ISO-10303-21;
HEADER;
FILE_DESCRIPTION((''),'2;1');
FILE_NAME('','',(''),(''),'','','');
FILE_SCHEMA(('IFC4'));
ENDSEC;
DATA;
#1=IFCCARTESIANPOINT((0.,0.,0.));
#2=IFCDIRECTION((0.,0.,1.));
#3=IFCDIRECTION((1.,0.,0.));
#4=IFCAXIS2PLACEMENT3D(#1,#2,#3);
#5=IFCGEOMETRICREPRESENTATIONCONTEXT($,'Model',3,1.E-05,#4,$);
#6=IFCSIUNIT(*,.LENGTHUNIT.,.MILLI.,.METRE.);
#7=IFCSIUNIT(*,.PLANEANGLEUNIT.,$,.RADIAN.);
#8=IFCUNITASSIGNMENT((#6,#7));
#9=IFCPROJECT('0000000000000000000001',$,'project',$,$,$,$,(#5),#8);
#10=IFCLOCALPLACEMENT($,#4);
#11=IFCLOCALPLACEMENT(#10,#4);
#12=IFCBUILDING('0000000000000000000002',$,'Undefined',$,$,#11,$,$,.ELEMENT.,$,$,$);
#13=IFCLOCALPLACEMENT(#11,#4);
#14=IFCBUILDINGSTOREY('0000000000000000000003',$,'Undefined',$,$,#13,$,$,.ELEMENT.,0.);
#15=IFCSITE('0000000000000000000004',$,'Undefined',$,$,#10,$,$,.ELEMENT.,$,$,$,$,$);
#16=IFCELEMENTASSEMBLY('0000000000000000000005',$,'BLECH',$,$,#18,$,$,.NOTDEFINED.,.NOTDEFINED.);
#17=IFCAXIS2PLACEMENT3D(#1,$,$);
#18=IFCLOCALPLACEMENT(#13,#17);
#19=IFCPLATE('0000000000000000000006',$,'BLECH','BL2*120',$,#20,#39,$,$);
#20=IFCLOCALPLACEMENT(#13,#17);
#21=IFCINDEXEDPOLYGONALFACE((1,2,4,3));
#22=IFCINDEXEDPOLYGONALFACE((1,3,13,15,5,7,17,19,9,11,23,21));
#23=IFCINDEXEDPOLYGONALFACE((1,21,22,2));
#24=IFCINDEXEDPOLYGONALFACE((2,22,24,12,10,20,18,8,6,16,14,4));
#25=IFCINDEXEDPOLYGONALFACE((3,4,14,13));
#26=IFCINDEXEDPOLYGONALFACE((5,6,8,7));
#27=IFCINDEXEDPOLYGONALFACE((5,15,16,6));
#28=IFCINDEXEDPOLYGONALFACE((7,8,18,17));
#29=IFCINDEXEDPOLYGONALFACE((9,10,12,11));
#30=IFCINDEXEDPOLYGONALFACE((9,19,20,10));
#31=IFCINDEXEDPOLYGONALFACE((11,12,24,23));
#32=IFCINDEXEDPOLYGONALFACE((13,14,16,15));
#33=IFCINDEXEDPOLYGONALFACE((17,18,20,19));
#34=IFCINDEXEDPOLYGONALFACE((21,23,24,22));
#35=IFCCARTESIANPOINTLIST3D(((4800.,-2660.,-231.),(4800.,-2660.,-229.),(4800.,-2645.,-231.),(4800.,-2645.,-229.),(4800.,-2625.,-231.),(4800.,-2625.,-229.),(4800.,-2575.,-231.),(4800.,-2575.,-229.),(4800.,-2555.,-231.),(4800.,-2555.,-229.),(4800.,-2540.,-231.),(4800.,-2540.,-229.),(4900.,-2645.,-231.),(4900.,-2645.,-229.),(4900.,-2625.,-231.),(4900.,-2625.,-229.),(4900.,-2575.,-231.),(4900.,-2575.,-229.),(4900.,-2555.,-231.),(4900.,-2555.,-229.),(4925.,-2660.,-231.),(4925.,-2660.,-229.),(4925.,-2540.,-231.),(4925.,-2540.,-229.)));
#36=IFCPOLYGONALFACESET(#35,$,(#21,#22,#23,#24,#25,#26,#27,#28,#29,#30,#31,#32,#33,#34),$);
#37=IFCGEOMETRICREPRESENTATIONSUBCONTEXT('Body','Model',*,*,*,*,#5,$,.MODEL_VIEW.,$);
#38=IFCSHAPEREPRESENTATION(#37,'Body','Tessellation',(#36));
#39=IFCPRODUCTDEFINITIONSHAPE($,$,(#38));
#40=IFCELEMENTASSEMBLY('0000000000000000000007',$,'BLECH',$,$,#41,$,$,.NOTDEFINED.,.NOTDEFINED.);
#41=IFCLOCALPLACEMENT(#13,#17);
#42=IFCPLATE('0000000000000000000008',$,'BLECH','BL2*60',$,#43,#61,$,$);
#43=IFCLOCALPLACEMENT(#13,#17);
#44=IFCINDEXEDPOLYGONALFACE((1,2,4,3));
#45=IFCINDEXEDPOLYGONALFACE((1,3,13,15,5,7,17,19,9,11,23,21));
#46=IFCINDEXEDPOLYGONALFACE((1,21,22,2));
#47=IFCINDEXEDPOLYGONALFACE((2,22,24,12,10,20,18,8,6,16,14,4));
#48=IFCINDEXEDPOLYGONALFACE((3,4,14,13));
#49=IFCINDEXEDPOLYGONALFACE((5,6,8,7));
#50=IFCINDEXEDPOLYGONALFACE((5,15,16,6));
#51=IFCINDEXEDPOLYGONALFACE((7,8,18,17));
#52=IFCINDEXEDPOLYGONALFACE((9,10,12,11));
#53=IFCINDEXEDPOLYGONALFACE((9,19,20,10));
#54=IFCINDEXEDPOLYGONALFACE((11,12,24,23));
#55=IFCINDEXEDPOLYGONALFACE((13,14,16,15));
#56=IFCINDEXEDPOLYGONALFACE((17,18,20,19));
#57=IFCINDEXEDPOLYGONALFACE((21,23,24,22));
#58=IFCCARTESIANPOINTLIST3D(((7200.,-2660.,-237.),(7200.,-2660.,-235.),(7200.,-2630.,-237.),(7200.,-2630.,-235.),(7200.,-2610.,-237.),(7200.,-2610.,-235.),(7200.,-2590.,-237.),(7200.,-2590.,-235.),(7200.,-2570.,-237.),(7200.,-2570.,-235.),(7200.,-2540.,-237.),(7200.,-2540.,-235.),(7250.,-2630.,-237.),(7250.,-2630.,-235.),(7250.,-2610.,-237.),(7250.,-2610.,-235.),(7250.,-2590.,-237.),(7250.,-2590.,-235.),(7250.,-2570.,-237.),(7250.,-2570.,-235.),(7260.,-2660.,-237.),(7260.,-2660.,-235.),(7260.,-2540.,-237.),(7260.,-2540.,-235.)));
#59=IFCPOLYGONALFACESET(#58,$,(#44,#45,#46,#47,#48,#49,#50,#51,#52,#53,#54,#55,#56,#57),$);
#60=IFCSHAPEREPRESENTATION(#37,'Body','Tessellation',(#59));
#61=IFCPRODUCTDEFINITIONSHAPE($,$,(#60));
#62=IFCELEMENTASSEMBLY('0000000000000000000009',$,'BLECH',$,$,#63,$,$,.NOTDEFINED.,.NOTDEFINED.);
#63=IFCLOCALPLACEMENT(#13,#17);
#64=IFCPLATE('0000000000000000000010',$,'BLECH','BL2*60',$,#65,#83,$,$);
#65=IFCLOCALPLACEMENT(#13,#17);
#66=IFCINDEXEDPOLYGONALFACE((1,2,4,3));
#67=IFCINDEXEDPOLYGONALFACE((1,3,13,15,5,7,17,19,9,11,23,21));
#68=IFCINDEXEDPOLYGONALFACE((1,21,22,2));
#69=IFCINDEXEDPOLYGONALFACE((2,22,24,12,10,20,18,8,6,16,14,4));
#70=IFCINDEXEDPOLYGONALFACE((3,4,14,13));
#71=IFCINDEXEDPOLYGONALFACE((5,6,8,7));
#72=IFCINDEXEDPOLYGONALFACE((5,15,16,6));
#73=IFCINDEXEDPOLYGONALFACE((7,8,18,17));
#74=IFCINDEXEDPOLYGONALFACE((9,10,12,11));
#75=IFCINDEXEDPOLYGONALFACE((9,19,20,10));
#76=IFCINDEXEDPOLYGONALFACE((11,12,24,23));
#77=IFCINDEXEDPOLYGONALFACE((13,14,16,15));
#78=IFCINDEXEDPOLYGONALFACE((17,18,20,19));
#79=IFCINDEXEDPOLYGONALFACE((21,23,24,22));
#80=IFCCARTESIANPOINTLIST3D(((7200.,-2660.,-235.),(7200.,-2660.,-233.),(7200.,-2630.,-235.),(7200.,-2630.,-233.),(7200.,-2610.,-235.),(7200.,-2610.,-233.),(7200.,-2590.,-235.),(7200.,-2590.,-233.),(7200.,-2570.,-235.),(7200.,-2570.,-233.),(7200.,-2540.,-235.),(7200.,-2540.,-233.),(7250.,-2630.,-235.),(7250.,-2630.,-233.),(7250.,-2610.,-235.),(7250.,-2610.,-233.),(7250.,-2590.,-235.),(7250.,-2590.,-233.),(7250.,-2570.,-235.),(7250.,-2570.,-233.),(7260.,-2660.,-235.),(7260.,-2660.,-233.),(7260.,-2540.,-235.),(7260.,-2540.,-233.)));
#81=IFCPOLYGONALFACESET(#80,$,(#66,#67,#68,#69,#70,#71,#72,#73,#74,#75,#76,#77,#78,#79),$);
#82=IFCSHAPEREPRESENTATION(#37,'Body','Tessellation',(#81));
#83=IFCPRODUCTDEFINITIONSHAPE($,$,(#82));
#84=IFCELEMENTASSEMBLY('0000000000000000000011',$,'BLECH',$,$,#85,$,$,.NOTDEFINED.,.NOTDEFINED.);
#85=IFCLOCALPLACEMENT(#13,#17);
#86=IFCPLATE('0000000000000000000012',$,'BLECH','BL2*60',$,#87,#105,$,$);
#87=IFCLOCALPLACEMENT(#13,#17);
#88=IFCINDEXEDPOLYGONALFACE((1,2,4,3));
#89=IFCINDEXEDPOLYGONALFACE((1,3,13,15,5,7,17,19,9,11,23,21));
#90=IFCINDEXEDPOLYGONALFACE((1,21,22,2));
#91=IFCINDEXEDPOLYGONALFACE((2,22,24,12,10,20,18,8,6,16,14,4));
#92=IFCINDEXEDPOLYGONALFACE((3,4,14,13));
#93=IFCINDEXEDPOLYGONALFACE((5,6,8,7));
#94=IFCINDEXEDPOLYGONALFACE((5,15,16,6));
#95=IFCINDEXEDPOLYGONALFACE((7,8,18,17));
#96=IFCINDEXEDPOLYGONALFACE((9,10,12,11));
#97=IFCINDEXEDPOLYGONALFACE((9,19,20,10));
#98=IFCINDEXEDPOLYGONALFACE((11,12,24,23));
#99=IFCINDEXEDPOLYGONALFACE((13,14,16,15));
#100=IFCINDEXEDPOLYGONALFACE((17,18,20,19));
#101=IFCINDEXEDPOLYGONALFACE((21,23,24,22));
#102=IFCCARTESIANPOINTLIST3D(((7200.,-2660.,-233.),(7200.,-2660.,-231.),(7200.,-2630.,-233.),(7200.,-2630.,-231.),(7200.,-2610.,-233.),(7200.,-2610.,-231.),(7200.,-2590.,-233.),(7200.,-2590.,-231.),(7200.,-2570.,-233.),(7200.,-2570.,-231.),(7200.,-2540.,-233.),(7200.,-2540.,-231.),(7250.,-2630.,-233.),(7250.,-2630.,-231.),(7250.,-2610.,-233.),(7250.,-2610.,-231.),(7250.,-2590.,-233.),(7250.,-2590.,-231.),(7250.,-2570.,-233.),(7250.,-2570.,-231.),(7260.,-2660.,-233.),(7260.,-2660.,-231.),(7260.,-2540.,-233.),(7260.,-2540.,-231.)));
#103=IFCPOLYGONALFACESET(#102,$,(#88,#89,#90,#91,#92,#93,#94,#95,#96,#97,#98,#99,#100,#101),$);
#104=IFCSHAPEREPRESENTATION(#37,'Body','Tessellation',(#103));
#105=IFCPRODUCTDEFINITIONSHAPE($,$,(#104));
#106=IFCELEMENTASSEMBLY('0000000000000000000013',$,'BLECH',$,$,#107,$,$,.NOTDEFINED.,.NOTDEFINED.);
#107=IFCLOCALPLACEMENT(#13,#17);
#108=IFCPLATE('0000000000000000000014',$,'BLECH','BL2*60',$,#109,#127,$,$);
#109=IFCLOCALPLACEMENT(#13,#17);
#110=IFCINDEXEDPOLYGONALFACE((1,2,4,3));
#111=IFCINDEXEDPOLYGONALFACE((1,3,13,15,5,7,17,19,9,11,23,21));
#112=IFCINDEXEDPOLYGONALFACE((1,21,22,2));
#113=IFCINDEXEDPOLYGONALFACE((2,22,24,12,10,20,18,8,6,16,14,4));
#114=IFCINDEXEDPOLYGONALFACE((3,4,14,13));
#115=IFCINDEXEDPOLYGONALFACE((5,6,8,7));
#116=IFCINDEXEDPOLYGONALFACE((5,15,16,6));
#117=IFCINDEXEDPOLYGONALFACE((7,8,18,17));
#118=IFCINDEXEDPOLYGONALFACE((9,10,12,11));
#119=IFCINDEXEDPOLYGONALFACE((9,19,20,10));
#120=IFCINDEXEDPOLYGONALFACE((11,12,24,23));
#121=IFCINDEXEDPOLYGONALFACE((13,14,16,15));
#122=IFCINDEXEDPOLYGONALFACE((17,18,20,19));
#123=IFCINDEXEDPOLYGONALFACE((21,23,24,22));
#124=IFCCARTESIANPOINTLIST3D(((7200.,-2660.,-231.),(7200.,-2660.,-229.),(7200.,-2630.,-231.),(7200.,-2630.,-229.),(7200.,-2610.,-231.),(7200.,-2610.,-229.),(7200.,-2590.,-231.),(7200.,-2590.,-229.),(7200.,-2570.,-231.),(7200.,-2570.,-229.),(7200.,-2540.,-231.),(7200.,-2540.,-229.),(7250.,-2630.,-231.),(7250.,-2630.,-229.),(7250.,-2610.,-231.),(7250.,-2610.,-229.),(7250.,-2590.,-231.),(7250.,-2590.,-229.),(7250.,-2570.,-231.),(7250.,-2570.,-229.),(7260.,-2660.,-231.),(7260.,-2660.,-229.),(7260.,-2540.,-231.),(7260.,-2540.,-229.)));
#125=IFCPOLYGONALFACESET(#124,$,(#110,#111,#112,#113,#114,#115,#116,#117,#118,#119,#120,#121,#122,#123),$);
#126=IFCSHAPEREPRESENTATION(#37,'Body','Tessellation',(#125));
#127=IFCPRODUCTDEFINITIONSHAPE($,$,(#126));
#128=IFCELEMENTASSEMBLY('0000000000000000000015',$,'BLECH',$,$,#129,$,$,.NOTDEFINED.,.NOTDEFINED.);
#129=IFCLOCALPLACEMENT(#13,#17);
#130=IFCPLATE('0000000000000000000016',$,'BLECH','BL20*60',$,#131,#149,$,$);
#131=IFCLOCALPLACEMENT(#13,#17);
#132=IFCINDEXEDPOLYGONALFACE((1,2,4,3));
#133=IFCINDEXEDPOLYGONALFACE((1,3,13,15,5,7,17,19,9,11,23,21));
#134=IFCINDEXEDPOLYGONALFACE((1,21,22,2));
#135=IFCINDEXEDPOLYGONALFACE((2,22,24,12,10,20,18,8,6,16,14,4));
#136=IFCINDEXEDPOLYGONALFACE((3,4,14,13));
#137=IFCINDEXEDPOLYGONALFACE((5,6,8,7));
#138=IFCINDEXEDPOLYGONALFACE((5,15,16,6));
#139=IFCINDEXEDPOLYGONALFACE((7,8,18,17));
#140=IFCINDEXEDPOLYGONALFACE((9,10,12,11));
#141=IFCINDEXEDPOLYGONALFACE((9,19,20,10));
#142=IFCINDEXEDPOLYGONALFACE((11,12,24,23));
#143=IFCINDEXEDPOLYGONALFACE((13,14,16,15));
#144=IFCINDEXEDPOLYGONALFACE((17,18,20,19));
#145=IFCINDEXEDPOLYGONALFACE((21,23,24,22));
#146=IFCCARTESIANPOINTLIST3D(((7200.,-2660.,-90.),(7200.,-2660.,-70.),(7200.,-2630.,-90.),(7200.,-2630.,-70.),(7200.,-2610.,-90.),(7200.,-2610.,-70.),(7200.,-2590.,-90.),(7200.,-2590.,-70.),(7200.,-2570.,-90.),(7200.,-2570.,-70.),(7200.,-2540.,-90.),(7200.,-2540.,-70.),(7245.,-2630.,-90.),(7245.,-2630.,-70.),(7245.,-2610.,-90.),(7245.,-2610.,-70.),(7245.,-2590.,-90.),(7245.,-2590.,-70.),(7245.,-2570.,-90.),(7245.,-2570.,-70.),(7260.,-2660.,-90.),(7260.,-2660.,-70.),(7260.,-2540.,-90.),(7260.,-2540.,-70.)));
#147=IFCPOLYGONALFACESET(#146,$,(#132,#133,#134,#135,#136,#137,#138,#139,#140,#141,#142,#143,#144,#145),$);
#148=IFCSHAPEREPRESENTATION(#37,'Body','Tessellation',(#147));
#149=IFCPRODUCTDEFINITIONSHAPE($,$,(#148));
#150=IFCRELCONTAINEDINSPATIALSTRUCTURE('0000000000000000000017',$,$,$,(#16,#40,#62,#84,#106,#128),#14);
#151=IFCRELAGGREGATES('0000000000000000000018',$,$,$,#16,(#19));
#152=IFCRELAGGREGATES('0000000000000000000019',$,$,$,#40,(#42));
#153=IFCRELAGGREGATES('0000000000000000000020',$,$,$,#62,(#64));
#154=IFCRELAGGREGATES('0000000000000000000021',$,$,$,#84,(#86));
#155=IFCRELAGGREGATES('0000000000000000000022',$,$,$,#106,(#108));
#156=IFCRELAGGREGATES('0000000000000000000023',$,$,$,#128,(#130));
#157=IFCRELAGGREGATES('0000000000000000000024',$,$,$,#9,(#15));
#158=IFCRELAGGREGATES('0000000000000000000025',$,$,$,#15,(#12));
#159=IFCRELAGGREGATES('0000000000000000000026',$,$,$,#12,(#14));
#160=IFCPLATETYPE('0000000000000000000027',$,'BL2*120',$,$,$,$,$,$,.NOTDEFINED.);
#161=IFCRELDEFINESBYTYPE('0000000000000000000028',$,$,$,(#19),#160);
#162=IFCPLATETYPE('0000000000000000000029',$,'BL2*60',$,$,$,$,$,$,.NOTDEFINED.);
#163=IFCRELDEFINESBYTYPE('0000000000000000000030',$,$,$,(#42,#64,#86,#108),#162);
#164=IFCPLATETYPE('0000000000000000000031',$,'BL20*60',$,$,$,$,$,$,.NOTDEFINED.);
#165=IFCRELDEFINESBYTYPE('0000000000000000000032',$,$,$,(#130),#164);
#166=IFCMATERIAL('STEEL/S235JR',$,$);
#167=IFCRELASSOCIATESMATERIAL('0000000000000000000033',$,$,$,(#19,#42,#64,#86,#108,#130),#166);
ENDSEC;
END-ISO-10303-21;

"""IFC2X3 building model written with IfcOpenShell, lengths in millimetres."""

from ifc_helpers import new_model, si_unit, frame, origin_with_axes, place, context, subcontext, project, spatial, polyline, outline, extrude, material, type_object, element, aggregate, save


model = new_model("IFC2X3")

# Units and contexts
model_context = context("Model", 3, precision=1e-05, world=origin_with_axes())
body_context = subcontext(model_context, "Body", "Model", "MODEL_VIEW")
ifc_project = project(units=[si_unit("LENGTHUNIT", "METRE", prefix="MILLI"), si_unit("PLANEANGLEUNIT", "RADIAN")], contexts=[model_context])

# Site, building, storey
site_placement = place(None, origin_with_axes())
site = spatial("IfcSite", under=ifc_project, at=site_placement, Name="Undefined", CompositionType="ELEMENT")
building_placement = place(site_placement, origin_with_axes())
building = spatial("IfcBuilding", under=site, at=building_placement, Name="Undefined", CompositionType="ELEMENT")
storey_placement = place(building_placement, origin_with_axes())
storey = spatial("IfcBuildingStorey", under=building, at=storey_placement, Name="Undefined", CompositionType="ELEMENT", Elevation=0.0)

# Shared definitions
ifc_material = material(Name="STEEL/S235JR")

# Element assemblies, plates
plate_type_1 = type_object("IfcPlateType", Name="BL2*120", PredefinedType="NOTDEFINED")
assembly_1_placement = place(storey_placement, origin_with_axes())
assembly_1 = element("IfcElementAssembly", 1, at=assembly_1_placement, inside=storey, Name="BLECH", AssemblyPlace="NOTDEFINED", PredefinedType="NOTDEFINED")
plate_1_placement = place(assembly_1_placement, frame((4925.0, -2540.0, -230.0), z_axis=(0.0, 0.0, 1.0), x_axis=(-1.0, 0.0, 0.0)))
plate_1 = element("IfcPlate", 2, at=plate_1_placement, type_object=plate_type_1, material=ifc_material, Name="BLECH", Description="BL2*120", context=body_context, shape_type="SweptSolid", body=[
    extrude(outline(polyline([(0.0, 0.0), (125.0, 0.0), (125.0, 15.0), (25.0, 15.0), (25.0, 35.0), (125.0, 35.0), (125.0, 85.0), (25.0, 85.0), (25.0, 105.0), (125.0, 105.0), (125.0, 120.0), (0.0, 120.0), (0.0, 0.0)])), frame((0.0, 0.0, -1.0), z_axis=(0.0, 0.0, 1.0), x_axis=(1.0, 0.0, 0.0)), (0.0, 0.0, 1.0), 2.0),
])
aggregate(assembly_1, [plate_1])
assembly_2_placement = place(storey_placement, origin_with_axes())
assembly_2 = element("IfcElementAssembly", 3, at=assembly_2_placement, inside=storey, Name="BLECH", AssemblyPlace="NOTDEFINED", PredefinedType="NOTDEFINED")
plate_type_2 = type_object("IfcPlateType", Name="BL2*60", PredefinedType="NOTDEFINED")
plate_2_placement = place(assembly_2_placement, frame((7260.0, -2540.0, -236.0), z_axis=(0.0, 0.0, 1.0), x_axis=(-1.0, 0.0, 0.0)))
plate_2 = element("IfcPlate", 4, at=plate_2_placement, type_object=plate_type_2, material=ifc_material, Name="BLECH", Description="BL2*60", context=body_context, shape_type="SweptSolid", body=[
    extrude(outline(polyline([(0.0, 0.0), (60.0, 0.0), (60.0, 30.0), (10.0, 30.0), (10.0, 50.0), (60.0, 50.0), (60.0, 70.0), (10.0, 70.0), (10.0, 90.0), (60.0, 90.0), (60.0, 120.0), (0.0, 120.0), (0.0, 0.0)])), frame((0.0, 0.0, -1.0), z_axis=(0.0, 0.0, 1.0), x_axis=(1.0, 0.0, 0.0)), (0.0, 0.0, 1.0), 2.0),
])
aggregate(assembly_2, [plate_2])
assembly_3_placement = place(storey_placement, origin_with_axes())
assembly_3 = element("IfcElementAssembly", 5, at=assembly_3_placement, inside=storey, Name="BLECH", AssemblyPlace="NOTDEFINED", PredefinedType="NOTDEFINED")
plate_3_placement = place(assembly_3_placement, frame((7260.0, -2540.0, -234.0), z_axis=(0.0, 0.0, 1.0), x_axis=(-1.0, 0.0, 0.0)))
plate_3 = element("IfcPlate", 6, at=plate_3_placement, type_object=plate_type_2, material=ifc_material, Name="BLECH", Description="BL2*60", context=body_context, shape_type="SweptSolid", body=[
    extrude(outline(polyline([(0.0, 0.0), (60.0, 0.0), (60.0, 30.0), (10.0, 30.0), (10.0, 50.0), (60.0, 50.0), (60.0, 70.0), (10.0, 70.0), (10.0, 90.0), (60.0, 90.0), (60.0, 120.0), (0.0, 120.0), (0.0, 0.0)])), frame((0.0, 0.0, -1.0), z_axis=(0.0, 0.0, 1.0), x_axis=(1.0, 0.0, 0.0)), (0.0, 0.0, 1.0), 2.0),
])
aggregate(assembly_3, [plate_3])
assembly_4_placement = place(storey_placement, origin_with_axes())
assembly_4 = element("IfcElementAssembly", 7, at=assembly_4_placement, inside=storey, Name="BLECH", AssemblyPlace="NOTDEFINED", PredefinedType="NOTDEFINED")
plate_4_placement = place(assembly_4_placement, frame((7260.0, -2540.0, -232.0), z_axis=(0.0, 0.0, 1.0), x_axis=(-1.0, 0.0, 0.0)))
plate_4 = element("IfcPlate", 8, at=plate_4_placement, type_object=plate_type_2, material=ifc_material, Name="BLECH", Description="BL2*60", context=body_context, shape_type="SweptSolid", body=[
    extrude(outline(polyline([(0.0, 0.0), (60.0, 0.0), (60.0, 30.0), (10.0, 30.0), (10.0, 50.0), (60.0, 50.0), (60.0, 70.0), (10.0, 70.0), (10.0, 90.0), (60.0, 90.0), (60.0, 120.0), (0.0, 120.0), (0.0, 0.0)])), frame((0.0, 0.0, -1.0), z_axis=(0.0, 0.0, 1.0), x_axis=(1.0, 0.0, 0.0)), (0.0, 0.0, 1.0), 2.0),
])
aggregate(assembly_4, [plate_4])
assembly_5_placement = place(storey_placement, origin_with_axes())
assembly_5 = element("IfcElementAssembly", 9, at=assembly_5_placement, inside=storey, Name="BLECH", AssemblyPlace="NOTDEFINED", PredefinedType="NOTDEFINED")
plate_5_placement = place(assembly_5_placement, frame((7260.0, -2540.0, -230.0), z_axis=(0.0, 0.0, 1.0), x_axis=(-1.0, 0.0, 0.0)))
plate_5 = element("IfcPlate", 10, at=plate_5_placement, type_object=plate_type_2, material=ifc_material, Name="BLECH", Description="BL2*60", context=body_context, shape_type="SweptSolid", body=[
    extrude(outline(polyline([(0.0, 0.0), (60.0, 0.0), (60.0, 30.0), (10.0, 30.0), (10.0, 50.0), (60.0, 50.0), (60.0, 70.0), (10.0, 70.0), (10.0, 90.0), (60.0, 90.0), (60.0, 120.0), (0.0, 120.0), (0.0, 0.0)])), frame((0.0, 0.0, -1.0), z_axis=(0.0, 0.0, 1.0), x_axis=(1.0, 0.0, 0.0)), (0.0, 0.0, 1.0), 2.0),
])
aggregate(assembly_5, [plate_5])
assembly_6_placement = place(storey_placement, origin_with_axes())
assembly_6 = element("IfcElementAssembly", 11, at=assembly_6_placement, inside=storey, Name="BLECH", AssemblyPlace="NOTDEFINED", PredefinedType="NOTDEFINED")
plate_type_3 = type_object("IfcPlateType", Name="BL20*60", PredefinedType="NOTDEFINED")
plate_6_placement = place(assembly_6_placement, frame((7260.0, -2540.0, -80.0), z_axis=(0.0, 0.0, 1.0), x_axis=(-1.0, 0.0, 0.0)))
plate_6 = element("IfcPlate", 12, at=plate_6_placement, type_object=plate_type_3, material=ifc_material, Name="BLECH", Description="BL20*60", context=body_context, shape_type="SweptSolid", body=[
    extrude(outline(polyline([(0.0, 0.0), (60.0, 0.0), (60.0, 30.0), (15.0, 30.0), (15.0, 50.0), (60.0, 50.0), (60.0, 70.0), (15.0, 70.0), (15.0, 90.0), (60.0, 90.0), (60.0, 120.0), (0.0, 120.0), (0.0, 0.0)])), frame((0.0, 0.0, -10.0), z_axis=(0.0, 0.0, 1.0), x_axis=(1.0, 0.0, 0.0)), (0.0, 0.0, 1.0), 20.0),
])
aggregate(assembly_6, [plate_6])

save(model, "model.ifc")
